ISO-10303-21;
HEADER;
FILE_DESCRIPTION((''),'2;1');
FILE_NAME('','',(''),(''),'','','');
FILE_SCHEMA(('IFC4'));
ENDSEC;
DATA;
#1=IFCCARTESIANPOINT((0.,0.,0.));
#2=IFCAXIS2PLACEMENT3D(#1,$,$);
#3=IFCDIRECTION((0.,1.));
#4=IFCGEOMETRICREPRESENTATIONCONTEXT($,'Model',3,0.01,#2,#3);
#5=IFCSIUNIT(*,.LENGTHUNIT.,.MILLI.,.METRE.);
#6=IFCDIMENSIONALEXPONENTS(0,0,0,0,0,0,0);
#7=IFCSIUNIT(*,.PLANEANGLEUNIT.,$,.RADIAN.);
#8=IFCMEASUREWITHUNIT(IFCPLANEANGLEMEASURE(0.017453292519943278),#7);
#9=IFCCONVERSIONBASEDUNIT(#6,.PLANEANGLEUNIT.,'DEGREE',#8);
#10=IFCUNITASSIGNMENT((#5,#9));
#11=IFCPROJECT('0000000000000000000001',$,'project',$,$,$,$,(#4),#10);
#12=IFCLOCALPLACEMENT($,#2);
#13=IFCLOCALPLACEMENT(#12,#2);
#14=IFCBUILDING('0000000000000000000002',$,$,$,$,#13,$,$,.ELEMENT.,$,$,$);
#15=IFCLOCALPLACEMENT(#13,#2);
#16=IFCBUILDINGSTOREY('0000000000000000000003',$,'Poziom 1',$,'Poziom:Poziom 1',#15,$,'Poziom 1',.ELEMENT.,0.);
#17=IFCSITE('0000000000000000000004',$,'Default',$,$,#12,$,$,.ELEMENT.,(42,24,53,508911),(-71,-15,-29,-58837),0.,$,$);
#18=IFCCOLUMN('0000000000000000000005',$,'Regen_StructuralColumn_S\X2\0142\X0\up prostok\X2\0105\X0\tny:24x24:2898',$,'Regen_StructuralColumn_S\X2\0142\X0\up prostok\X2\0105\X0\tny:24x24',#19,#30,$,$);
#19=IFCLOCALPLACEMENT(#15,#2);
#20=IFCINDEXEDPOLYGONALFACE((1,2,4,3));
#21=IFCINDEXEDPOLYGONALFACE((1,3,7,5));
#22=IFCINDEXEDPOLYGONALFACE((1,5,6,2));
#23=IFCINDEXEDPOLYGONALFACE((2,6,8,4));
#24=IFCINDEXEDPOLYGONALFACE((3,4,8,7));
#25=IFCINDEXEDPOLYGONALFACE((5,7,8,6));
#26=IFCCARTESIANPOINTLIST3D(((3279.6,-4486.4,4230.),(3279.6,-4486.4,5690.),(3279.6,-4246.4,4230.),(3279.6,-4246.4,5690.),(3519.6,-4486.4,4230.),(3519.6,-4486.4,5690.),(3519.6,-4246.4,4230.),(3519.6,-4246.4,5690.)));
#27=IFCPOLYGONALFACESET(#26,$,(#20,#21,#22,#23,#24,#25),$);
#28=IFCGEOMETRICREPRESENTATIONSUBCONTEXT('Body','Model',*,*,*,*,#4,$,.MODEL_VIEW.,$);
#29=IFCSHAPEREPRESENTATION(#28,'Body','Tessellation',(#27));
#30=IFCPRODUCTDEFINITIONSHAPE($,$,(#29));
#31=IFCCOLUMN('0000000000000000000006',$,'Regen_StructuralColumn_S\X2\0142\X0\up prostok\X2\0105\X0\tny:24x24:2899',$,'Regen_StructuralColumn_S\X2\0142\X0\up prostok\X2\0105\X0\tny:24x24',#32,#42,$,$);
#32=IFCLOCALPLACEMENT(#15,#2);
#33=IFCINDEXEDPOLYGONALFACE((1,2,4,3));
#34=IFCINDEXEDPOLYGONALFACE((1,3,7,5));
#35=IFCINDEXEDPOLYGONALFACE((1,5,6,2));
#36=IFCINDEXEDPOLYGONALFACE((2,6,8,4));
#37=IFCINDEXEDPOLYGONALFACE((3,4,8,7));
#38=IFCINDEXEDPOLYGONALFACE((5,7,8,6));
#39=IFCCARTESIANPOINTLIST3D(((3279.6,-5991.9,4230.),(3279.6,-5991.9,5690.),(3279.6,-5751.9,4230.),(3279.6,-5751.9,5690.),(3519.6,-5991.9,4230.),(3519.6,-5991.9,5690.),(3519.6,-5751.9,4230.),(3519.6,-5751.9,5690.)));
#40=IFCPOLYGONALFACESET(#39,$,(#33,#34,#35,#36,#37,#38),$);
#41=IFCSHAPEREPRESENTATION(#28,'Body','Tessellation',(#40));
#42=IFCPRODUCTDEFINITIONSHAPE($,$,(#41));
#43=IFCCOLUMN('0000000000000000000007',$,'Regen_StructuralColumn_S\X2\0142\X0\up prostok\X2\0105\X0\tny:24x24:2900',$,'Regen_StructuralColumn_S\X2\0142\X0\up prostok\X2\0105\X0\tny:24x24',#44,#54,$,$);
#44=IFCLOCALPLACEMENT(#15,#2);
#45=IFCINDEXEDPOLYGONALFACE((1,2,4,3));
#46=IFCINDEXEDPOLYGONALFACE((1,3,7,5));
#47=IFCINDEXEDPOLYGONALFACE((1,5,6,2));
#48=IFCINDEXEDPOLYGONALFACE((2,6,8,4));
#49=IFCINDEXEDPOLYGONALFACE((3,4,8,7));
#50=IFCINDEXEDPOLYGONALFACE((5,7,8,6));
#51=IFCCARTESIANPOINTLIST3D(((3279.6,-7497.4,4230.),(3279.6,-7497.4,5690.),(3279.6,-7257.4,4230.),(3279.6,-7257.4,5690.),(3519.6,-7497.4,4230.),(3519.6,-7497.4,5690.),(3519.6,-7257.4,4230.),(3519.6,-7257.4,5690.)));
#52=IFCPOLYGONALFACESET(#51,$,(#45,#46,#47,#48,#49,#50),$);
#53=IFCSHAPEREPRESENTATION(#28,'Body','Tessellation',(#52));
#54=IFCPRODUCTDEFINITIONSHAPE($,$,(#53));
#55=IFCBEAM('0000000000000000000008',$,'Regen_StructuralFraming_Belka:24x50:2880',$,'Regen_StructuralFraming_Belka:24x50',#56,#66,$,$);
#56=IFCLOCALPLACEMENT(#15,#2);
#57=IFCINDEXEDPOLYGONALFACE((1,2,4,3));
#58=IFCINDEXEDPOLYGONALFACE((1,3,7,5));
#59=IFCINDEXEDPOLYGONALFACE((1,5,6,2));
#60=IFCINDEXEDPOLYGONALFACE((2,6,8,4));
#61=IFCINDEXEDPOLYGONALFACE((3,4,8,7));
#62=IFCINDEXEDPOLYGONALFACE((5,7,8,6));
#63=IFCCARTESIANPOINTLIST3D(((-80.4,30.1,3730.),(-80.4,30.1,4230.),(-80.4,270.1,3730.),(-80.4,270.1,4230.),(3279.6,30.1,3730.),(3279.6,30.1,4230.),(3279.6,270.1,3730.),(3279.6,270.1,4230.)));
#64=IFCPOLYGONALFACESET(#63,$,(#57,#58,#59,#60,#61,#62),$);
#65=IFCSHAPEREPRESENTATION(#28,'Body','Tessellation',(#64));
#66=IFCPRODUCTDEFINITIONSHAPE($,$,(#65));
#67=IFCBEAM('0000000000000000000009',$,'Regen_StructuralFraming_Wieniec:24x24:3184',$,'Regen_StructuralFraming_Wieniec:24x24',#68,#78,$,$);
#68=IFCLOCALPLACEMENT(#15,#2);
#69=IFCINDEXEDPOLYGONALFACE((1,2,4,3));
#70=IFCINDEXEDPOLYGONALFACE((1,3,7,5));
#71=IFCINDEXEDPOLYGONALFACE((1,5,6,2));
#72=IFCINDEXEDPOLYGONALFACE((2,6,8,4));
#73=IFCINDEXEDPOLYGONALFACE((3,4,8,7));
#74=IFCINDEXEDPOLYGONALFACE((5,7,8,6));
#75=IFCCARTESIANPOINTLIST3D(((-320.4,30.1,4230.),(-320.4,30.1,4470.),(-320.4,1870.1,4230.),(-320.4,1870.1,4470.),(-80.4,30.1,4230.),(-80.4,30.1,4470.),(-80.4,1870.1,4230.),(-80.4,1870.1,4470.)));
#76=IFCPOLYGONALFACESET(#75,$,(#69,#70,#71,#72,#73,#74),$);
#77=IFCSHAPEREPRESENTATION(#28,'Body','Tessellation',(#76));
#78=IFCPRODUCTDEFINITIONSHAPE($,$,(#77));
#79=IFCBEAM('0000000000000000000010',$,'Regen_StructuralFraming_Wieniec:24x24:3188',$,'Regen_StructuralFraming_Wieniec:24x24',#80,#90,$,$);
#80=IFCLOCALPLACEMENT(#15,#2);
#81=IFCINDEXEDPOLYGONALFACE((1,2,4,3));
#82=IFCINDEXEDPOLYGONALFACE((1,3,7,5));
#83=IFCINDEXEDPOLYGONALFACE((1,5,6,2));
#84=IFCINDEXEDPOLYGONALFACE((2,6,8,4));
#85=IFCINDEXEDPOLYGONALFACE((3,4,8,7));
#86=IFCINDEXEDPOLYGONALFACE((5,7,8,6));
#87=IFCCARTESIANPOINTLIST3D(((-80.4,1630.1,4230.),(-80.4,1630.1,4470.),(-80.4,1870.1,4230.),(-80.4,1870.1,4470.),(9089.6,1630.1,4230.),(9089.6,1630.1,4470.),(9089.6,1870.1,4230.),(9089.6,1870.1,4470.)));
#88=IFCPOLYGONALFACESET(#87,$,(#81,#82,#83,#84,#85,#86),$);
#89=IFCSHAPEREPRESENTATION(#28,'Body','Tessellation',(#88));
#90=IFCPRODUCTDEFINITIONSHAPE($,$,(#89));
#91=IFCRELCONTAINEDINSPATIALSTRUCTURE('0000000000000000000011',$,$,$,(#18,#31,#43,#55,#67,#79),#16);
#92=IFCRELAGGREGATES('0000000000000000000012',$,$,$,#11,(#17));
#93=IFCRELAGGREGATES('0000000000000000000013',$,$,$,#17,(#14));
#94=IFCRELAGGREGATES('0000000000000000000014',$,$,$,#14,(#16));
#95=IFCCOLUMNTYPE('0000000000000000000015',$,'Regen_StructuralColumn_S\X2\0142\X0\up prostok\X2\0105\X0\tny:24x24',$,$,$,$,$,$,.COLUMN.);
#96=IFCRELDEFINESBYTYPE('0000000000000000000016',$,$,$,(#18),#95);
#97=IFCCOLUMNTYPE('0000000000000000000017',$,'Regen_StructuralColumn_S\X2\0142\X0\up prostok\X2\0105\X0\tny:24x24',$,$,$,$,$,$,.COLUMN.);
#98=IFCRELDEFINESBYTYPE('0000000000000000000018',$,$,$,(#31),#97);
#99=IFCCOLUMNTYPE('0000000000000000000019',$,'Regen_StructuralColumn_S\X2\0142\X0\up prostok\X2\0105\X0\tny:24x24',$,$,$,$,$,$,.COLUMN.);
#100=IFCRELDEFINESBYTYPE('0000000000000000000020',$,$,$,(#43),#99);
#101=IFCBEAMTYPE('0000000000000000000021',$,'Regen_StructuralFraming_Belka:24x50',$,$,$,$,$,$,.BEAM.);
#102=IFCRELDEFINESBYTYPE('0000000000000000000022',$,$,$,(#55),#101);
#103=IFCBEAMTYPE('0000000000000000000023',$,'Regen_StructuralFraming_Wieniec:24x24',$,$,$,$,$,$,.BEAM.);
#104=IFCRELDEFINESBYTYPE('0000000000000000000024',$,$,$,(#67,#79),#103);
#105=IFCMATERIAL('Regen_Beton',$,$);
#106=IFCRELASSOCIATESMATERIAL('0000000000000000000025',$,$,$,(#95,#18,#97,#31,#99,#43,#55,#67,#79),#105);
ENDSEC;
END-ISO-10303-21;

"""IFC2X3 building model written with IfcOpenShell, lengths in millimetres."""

from ifc_helpers import new_model, entity, si_unit, converted_unit, direction, frame, frame_2d, origin, place, context, subcontext, project, spatial, rectangle, extrude, source, transform, mapped, material, type_object, type_shapes, element, save


model = new_model("IFC2X3")

# Units and contexts
model_context = context("Model", 3, precision=0.01, world=origin(), true_north=direction((0.0, 1.0)))
body_context = subcontext(model_context, "Body", "Model", "MODEL_VIEW")
ifc_project = project(units=[si_unit("LENGTHUNIT", "METRE", prefix="MILLI"), converted_unit("PLANEANGLEUNIT", "DEGREE", entity("IfcPlaneAngleMeasure", 0.017453292519943278), si_unit("PLANEANGLEUNIT", "RADIAN"), dimensions=[0, 0, 0, 0, 0, 0, 0])], contexts=[model_context])

# Site, building, storey
site_placement = place(None, origin())
site = spatial("IfcSite", under=ifc_project, at=site_placement, Name="Default", CompositionType="ELEMENT", RefLatitude=(42, 24, 53, 508911), RefLongitude=(-71, -15, -29, -58837), RefElevation=0.0)
building_placement = place(site_placement, origin())
building = spatial("IfcBuilding", under=site, at=building_placement, CompositionType="ELEMENT")
storey_placement = place(building_placement, origin())
storey = spatial("IfcBuildingStorey", under=building, at=storey_placement, Name="Poziom 1", ObjectType="Poziom:Poziom 1", LongName="Poziom 1", CompositionType="ELEMENT", Elevation=0.0)

# Columns
ifc_material_1 = material(Name="Regen_Beton")
column_type_1 = type_object("IfcColumnType", Name="Regen_StructuralColumn_Słup prostokątny:24x24", PredefinedType="COLUMN", material=ifc_material_1)
shared_shape_1 = source(origin(), body_context, "Body", "SweptSolid", [
    extrude(rectangle(XDim=240.0, YDim=240.0, at=frame_2d((0.0, 0.0), x_axis=(1.0, 0.0))), frame((3399.6, -4366.4, 4230.0), z_axis=(0.0, 0.0, 1.0), x_axis=(-1.0, 0.0, 0.0)), (0.0, 0.0, 1.0), 1460.0),
])
type_shapes(column_type_1, [shared_shape_1])
column_1_placement = place(storey_placement, origin())
element("IfcColumn", 1, at=column_1_placement, inside=storey, type_object=column_type_1, material=ifc_material_1, Name="Regen_StructuralColumn_Słup prostokątny:24x24:2898", ObjectType="Regen_StructuralColumn_Słup prostokątny:24x24", context=body_context, shape_type="MappedRepresentation", body=[
    mapped(shared_shape_1, transform((0.0, 0.0, 0.0), scale=1.0)),
])
column_type_2 = type_object("IfcColumnType", Name="Regen_StructuralColumn_Słup prostokątny:24x24", PredefinedType="COLUMN", material=ifc_material_1)
shared_shape_2 = source(origin(), body_context, "Body", "SweptSolid", [
    extrude(rectangle(XDim=240.0, YDim=240.0, at=frame_2d((0.0, 0.0), x_axis=(1.0, 0.0))), frame((3399.6, -5871.9, 4230.0), z_axis=(0.0, 0.0, 1.0), x_axis=(-1.0, 0.0, 0.0)), (0.0, 0.0, 1.0), 1460.0),
])
type_shapes(column_type_2, [shared_shape_2])
column_2_placement = place(storey_placement, origin())
element("IfcColumn", 2, at=column_2_placement, inside=storey, type_object=column_type_2, material=ifc_material_1, Name="Regen_StructuralColumn_Słup prostokątny:24x24:2899", ObjectType="Regen_StructuralColumn_Słup prostokątny:24x24", context=body_context, shape_type="MappedRepresentation", body=[
    mapped(shared_shape_2, transform((0.0, 0.0, 0.0), scale=1.0)),
])
column_type_3 = type_object("IfcColumnType", Name="Regen_StructuralColumn_Słup prostokątny:24x24", PredefinedType="COLUMN", material=ifc_material_1)
shared_shape_3 = source(origin(), body_context, "Body", "SweptSolid", [
    extrude(rectangle(XDim=240.0, YDim=240.0, at=frame_2d((0.0, 0.0), x_axis=(1.0, 0.0))), frame((3399.6, -7377.4, 4230.0), z_axis=(0.0, 0.0, 1.0), x_axis=(-1.0, 0.0, 0.0)), (0.0, 0.0, 1.0), 1460.0),
])
type_shapes(column_type_3, [shared_shape_3])
column_3_placement = place(storey_placement, origin())
element("IfcColumn", 3, at=column_3_placement, inside=storey, type_object=column_type_3, material=ifc_material_1, Name="Regen_StructuralColumn_Słup prostokątny:24x24:2900", ObjectType="Regen_StructuralColumn_Słup prostokątny:24x24", context=body_context, shape_type="MappedRepresentation", body=[
    mapped(shared_shape_3, transform((0.0, 0.0, 0.0), scale=1.0)),
])

# Beams
beam_type_1 = type_object("IfcBeamType", Name="Regen_StructuralFraming_Belka:24x50", PredefinedType="BEAM")
beam_1_placement = place(storey_placement, frame((-80.4, 150.1, 4230.0)))
element("IfcBeam", 4, at=beam_1_placement, inside=storey, type_object=beam_type_1, material=ifc_material_1, Name="Regen_StructuralFraming_Belka:24x50:2880", ObjectType="Regen_StructuralFraming_Belka:24x50", context=body_context, shape_type="SweptSolid", body=[
    extrude(rectangle(XDim=500.0, YDim=240.0, at=frame_2d((0.0, 0.0), x_axis=(1.0, 0.0))), frame((0.0, 0.0, -250.0), z_axis=(1.0, 0.0, 0.0), x_axis=(0.0, 0.0, -1.0)), (0.0, 0.0, 1.0), 3360.0),
])
beam_type_2 = type_object("IfcBeamType", Name="Regen_StructuralFraming_Wieniec:24x24", PredefinedType="BEAM")
beam_2_placement = place(storey_placement, frame((-200.4, 30.1, 4230.0), z_axis=(0.0, 0.0, 1.0), x_axis=(0.0, 1.0, 0.0)))
element("IfcBeam", 5, at=beam_2_placement, inside=storey, type_object=beam_type_2, material=ifc_material_1, Name="Regen_StructuralFraming_Wieniec:24x24:3184", ObjectType="Regen_StructuralFraming_Wieniec:24x24", context=body_context, shape_type="SweptSolid", body=[
    extrude(rectangle(XDim=240.0, YDim=240.0, at=frame_2d((0.0, 0.0), x_axis=(1.0, 0.0))), frame((0.0, 0.0, 120.0), z_axis=(1.0, 0.0, 0.0), x_axis=(0.0, 0.0, -1.0)), (0.0, 0.0, 1.0), 1840.0),
])
beam_3_placement = place(storey_placement, frame((-200.4, 1750.1, 4230.0)))
element("IfcBeam", 6, at=beam_3_placement, inside=storey, type_object=beam_type_2, material=ifc_material_1, Name="Regen_StructuralFraming_Wieniec:24x24:3188", ObjectType="Regen_StructuralFraming_Wieniec:24x24", context=body_context, shape_type="SweptSolid", body=[
    extrude(rectangle(XDim=240.0, YDim=240.0, at=frame_2d((0.0, 0.0), x_axis=(1.0, 0.0))), frame((120.0, 0.0, 120.0), z_axis=(1.0, 0.0, 0.0), x_axis=(0.0, 0.0, -1.0)), (0.0, 0.0, 1.0), 9170.0),
])

save(model, "model.ifc")
